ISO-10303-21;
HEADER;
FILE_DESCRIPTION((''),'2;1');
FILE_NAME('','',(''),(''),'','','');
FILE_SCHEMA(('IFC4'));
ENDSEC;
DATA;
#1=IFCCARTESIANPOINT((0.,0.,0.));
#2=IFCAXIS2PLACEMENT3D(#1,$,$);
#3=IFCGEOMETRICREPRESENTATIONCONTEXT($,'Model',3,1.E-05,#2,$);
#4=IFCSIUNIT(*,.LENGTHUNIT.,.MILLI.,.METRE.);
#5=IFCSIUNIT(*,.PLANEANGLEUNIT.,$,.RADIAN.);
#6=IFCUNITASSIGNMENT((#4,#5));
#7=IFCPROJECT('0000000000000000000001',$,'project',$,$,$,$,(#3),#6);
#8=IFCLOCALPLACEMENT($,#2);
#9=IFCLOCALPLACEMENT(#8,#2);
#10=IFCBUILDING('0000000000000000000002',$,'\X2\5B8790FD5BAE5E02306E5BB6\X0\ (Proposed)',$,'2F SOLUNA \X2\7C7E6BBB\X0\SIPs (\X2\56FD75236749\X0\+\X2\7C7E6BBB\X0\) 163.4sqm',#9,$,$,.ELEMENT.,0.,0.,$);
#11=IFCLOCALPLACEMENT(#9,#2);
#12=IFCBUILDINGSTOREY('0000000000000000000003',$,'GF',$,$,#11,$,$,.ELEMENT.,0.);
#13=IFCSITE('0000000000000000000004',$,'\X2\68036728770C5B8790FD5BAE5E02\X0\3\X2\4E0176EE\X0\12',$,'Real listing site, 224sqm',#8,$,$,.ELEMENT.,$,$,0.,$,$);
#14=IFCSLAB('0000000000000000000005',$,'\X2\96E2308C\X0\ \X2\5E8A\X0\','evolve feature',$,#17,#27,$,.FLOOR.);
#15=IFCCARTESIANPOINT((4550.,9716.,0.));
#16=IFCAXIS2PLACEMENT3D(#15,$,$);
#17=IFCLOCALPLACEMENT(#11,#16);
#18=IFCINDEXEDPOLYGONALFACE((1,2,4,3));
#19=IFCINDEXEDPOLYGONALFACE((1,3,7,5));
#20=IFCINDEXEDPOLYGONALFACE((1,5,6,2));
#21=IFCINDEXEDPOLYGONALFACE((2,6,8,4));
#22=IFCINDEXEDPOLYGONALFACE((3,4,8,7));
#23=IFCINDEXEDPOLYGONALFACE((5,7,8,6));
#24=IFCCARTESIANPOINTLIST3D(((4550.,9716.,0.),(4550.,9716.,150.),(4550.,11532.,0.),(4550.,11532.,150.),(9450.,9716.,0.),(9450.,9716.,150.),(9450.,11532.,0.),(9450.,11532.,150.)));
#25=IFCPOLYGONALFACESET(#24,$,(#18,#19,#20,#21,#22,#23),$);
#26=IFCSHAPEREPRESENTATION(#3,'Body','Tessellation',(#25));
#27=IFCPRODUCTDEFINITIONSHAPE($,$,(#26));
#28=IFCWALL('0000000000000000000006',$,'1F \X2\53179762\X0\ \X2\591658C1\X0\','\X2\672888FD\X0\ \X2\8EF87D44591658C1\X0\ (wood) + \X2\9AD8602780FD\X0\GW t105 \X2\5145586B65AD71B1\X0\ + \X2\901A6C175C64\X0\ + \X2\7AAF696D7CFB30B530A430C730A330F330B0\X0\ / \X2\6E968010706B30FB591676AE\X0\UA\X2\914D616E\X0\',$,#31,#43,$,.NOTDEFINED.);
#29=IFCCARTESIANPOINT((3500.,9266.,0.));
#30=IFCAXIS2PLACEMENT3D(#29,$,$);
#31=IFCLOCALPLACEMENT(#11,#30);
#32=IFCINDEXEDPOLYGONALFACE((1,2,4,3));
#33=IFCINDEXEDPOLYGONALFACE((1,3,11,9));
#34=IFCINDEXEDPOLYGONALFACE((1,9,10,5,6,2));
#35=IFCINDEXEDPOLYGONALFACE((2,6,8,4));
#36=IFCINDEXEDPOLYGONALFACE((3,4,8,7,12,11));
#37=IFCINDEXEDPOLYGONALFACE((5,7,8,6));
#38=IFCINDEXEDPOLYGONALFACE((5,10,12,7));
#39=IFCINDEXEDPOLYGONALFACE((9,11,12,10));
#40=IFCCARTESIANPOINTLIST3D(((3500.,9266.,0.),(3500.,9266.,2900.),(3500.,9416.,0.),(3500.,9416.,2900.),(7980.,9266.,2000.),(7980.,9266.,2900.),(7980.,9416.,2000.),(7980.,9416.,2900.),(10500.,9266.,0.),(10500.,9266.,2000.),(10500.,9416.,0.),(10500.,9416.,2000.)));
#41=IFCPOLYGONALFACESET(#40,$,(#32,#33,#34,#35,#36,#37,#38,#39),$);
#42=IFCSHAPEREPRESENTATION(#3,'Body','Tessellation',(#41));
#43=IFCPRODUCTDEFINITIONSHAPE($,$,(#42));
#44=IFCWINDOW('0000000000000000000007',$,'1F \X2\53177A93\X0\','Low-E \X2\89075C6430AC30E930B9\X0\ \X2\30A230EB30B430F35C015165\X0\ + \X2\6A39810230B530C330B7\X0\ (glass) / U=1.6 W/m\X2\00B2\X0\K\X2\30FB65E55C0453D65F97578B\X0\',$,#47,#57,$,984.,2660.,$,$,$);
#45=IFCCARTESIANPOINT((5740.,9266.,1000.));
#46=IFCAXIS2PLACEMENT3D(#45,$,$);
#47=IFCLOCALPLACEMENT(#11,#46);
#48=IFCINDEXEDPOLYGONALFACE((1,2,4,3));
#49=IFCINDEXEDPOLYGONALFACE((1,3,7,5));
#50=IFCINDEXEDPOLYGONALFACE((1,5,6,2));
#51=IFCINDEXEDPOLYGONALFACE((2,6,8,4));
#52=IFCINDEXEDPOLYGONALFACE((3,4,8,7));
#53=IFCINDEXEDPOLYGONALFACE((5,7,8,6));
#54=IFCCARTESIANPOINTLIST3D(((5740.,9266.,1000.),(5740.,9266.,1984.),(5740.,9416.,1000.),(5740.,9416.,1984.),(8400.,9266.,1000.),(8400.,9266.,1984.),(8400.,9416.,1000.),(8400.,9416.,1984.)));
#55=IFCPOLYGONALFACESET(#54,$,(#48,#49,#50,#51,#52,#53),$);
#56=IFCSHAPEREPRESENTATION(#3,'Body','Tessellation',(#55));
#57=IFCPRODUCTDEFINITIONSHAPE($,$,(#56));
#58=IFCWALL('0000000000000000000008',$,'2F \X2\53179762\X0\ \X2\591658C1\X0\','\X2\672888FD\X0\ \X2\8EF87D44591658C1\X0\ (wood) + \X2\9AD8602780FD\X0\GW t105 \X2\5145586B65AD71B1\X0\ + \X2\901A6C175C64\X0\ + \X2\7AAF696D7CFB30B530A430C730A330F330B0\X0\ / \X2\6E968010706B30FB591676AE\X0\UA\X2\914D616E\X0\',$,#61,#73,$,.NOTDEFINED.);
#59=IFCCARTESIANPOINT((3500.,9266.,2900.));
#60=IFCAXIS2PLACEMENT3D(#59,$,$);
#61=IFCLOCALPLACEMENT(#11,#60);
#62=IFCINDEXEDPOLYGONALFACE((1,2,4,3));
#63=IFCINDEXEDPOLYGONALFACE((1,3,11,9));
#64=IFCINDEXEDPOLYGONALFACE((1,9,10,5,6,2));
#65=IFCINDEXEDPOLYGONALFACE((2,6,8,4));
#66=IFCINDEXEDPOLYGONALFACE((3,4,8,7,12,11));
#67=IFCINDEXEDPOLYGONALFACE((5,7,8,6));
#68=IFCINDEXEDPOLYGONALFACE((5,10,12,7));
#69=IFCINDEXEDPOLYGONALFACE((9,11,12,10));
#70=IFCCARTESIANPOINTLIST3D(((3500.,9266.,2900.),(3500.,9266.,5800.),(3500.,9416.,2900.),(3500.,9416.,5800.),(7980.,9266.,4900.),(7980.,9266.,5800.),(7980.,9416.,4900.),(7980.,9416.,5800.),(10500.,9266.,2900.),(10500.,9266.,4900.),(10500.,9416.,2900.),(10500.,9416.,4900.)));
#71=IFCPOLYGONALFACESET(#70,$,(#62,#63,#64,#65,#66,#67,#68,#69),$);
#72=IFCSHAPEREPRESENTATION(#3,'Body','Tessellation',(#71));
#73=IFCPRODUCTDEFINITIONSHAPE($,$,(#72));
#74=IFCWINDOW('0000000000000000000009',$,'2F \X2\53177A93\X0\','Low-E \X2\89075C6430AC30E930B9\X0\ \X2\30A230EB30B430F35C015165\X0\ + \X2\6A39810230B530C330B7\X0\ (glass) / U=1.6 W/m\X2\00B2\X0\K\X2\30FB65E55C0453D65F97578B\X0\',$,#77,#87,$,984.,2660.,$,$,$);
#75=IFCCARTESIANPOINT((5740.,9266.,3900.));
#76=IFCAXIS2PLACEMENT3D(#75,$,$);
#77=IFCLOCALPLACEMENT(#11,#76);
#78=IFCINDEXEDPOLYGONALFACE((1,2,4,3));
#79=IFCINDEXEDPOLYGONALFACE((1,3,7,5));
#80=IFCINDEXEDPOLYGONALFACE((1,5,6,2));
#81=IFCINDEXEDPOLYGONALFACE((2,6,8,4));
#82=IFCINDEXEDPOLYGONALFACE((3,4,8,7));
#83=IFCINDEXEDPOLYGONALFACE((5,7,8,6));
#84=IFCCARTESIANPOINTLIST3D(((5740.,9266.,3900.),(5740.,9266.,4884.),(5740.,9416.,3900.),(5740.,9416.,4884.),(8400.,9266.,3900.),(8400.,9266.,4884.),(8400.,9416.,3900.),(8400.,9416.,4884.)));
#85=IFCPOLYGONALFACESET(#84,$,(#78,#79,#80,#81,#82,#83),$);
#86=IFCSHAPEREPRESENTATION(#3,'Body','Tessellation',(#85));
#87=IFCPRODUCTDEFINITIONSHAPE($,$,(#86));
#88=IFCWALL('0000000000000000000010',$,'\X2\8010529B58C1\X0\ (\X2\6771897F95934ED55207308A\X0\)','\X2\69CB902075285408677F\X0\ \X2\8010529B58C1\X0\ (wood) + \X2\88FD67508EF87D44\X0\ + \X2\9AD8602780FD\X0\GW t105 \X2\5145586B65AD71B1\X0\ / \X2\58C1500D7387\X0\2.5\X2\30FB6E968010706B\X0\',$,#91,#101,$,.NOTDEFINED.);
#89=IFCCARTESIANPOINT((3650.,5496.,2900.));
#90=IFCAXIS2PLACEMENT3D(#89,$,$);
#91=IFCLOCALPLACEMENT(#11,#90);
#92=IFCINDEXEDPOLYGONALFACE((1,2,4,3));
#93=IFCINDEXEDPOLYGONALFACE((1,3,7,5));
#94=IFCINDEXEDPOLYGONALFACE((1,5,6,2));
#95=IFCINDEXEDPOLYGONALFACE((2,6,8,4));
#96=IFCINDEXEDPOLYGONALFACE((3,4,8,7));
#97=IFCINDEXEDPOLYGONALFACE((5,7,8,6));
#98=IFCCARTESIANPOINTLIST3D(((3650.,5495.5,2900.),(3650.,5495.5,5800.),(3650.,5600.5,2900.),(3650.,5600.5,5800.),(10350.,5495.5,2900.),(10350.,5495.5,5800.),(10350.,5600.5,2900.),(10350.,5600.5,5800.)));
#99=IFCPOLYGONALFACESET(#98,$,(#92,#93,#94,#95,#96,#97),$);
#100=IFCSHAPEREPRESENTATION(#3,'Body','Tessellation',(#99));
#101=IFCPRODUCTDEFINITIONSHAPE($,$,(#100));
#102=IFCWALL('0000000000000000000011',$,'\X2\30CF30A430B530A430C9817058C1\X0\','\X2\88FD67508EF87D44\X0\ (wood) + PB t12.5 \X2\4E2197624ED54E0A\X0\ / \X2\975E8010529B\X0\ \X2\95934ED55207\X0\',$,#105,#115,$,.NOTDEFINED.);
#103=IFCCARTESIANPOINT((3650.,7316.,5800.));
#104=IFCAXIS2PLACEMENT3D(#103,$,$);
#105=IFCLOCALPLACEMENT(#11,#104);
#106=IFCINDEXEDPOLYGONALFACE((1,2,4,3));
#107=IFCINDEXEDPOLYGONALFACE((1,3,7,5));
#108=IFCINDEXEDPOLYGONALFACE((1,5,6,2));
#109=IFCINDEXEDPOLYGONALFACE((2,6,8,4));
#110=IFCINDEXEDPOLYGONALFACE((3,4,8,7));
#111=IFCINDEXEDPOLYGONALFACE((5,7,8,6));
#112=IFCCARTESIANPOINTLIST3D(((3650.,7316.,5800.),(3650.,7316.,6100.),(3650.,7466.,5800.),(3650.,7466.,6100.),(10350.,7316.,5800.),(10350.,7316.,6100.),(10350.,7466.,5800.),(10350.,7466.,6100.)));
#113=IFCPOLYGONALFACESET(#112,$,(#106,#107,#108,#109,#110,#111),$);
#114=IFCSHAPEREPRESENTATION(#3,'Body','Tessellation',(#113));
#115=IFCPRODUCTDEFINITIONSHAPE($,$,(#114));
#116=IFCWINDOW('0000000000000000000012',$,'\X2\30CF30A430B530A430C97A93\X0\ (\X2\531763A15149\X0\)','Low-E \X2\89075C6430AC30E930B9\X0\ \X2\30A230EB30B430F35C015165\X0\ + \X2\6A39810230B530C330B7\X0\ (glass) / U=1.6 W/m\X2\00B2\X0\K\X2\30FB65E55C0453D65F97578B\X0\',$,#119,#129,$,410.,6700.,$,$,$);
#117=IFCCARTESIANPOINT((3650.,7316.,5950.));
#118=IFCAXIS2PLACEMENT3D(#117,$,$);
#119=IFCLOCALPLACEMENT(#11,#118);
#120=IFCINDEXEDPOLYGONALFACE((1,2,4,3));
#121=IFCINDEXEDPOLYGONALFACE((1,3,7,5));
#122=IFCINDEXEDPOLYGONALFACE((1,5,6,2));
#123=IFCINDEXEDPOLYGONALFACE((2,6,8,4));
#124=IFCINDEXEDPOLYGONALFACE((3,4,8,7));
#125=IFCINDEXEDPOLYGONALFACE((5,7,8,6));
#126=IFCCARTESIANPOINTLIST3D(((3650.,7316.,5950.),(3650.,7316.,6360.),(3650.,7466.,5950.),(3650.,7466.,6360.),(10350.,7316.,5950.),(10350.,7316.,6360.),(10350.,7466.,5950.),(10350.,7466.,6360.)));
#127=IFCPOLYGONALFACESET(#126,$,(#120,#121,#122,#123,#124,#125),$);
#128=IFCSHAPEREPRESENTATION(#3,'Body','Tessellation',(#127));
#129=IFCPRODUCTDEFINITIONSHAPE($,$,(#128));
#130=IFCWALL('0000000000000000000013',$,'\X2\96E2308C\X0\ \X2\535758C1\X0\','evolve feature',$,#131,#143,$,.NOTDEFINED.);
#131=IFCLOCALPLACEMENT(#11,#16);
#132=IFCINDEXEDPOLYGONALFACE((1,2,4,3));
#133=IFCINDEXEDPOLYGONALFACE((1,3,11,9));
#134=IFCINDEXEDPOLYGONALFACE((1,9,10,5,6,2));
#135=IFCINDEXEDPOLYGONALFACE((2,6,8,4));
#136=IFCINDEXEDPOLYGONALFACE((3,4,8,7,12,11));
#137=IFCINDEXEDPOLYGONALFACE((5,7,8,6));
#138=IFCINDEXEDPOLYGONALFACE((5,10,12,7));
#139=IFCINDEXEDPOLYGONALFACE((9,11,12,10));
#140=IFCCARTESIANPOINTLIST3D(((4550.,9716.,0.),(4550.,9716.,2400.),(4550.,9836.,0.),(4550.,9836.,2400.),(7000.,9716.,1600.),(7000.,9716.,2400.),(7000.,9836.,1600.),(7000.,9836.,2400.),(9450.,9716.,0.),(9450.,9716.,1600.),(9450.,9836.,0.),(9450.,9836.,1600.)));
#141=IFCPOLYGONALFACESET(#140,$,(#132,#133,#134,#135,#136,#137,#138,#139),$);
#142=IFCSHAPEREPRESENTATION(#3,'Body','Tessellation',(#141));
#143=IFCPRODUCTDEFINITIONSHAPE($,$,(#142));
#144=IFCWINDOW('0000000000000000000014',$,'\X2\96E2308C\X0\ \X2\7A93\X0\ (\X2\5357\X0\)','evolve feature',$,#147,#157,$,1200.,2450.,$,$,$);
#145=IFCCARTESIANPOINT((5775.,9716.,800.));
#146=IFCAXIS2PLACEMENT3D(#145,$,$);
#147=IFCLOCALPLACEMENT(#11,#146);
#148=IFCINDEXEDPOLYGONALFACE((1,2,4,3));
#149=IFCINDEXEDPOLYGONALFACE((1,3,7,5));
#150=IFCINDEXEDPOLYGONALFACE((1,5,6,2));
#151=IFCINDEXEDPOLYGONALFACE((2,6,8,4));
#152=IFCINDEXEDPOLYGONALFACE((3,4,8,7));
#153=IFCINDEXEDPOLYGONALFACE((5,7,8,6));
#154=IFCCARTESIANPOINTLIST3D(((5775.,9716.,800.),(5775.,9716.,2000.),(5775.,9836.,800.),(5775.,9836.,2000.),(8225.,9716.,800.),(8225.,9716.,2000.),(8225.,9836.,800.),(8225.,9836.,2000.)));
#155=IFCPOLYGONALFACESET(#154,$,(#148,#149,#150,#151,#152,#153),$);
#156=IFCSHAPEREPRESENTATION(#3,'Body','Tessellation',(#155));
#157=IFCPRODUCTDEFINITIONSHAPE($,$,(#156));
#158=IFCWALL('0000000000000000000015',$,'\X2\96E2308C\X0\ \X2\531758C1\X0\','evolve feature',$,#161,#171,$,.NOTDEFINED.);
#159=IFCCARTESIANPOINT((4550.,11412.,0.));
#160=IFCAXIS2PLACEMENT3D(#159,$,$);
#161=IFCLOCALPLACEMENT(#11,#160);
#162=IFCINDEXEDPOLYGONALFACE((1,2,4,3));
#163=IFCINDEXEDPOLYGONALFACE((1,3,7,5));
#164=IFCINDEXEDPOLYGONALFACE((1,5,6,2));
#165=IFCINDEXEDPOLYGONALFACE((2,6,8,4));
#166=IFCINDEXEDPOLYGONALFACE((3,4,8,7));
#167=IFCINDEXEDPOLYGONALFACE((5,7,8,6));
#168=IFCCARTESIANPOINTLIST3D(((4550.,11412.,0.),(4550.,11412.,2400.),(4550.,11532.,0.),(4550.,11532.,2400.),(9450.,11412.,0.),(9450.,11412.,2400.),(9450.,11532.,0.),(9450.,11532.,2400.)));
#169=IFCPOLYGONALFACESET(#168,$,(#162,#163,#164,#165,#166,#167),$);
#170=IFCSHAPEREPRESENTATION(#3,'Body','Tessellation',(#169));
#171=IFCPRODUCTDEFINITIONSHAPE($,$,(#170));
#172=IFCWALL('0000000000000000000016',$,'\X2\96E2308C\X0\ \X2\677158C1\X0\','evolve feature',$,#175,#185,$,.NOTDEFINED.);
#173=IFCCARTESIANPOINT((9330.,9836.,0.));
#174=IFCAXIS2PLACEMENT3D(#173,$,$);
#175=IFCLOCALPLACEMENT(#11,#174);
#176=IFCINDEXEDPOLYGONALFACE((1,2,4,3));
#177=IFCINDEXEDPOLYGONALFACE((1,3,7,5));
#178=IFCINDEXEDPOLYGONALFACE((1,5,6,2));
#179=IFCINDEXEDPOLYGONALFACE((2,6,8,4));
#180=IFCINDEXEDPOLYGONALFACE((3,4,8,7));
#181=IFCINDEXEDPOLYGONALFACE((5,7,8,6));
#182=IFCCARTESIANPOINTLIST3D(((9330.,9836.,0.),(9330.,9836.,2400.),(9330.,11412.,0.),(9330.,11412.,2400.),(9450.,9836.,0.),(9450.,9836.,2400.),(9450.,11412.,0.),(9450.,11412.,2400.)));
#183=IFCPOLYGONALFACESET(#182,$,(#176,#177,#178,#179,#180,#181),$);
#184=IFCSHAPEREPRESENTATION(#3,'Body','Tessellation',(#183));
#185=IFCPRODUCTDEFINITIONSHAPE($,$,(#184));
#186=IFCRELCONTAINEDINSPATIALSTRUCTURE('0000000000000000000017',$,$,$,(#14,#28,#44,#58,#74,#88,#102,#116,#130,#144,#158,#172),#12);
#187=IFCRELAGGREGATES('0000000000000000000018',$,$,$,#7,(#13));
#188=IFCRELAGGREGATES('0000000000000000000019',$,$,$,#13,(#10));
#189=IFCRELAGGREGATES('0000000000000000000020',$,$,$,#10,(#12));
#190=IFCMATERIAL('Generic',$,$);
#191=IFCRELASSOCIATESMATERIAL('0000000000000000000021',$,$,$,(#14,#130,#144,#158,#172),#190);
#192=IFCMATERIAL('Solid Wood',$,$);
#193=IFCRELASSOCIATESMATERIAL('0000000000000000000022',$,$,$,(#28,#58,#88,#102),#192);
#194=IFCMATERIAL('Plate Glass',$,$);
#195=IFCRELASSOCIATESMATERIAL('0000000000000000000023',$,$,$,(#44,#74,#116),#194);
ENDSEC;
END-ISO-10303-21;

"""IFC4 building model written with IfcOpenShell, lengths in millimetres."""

from ifc_helpers import new_model, si_unit, frame, frame_2d, origin, place, context, project, spatial, rectangle, extrude, material, element, fill, save


model = new_model("IFC4")

# Units and contexts
model_context = context("Model", 3, precision=1e-05, world=origin())
ifc_project = project(units=[si_unit("LENGTHUNIT", "METRE", prefix="MILLI"), si_unit("PLANEANGLEUNIT", "RADIAN")], contexts=[model_context])

# Site, building, storey
site_placement = place(None, origin())
site = spatial("IfcSite", under=ifc_project, at=site_placement, Name="栃木県宇都宮市3丁目12", ObjectType="Real listing site, 224sqm", CompositionType="ELEMENT", RefElevation=0.0)
building_placement = place(site_placement, origin())
building = spatial("IfcBuilding", under=site, at=building_placement, Name="宇都宮市の家 (Proposed)", ObjectType="2F SOLUNA 籾殻SIPs (国産杉+籾殻) 163.4sqm", CompositionType="ELEMENT", ElevationOfRefHeight=0.0, ElevationOfTerrain=0.0)
storey_placement = place(building_placement, origin())
storey = spatial("IfcBuildingStorey", under=building, at=storey_placement, Name="GF", CompositionType="ELEMENT", Elevation=0.0)

# Slab
ifc_material_1 = material(Name="Generic")
slab_placement = place(storey_placement, frame((4550.0, 9716.0, 0.0)))
element("IfcSlab", 1, at=slab_placement, inside=storey, material=ifc_material_1, Name="離れ 床", Description="evolve feature", PredefinedType="FLOOR", context=model_context, shape_type="SweptSolid", body=[
    extrude(rectangle(XDim=4900.0, YDim=1816.0, at=frame_2d((2450.0, 908.0))), frame((4550.0, 9716.0, 0.0)), (0.0, 0.0, 1.0), 150.0),
])

# Wall, opening, window
ifc_material_2 = material(Name="Solid Wood")
wall_1_placement = place(storey_placement, frame((3500.0, 9266.0, 0.0)))
wall_1 = element("IfcWall", 2, at=wall_1_placement, inside=storey, material=ifc_material_2, Name="1F 北面 外壁", Description="木製 軸組外壁 (wood) + 高性能GW t105 充填断熱 + 通気層 + 窯業系サイディング / 準耐火・外皮UA配慮", PredefinedType="NOTDEFINED", context=model_context, shape_type="SweptSolid", body=[
    extrude(rectangle(XDim=7000.0, YDim=150.0, at=frame_2d((3500.0, 75.0))), frame((3500.0, 9266.0, 0.0)), (0.0, 0.0, 1.0), 2900.0),
])
opening_1_placement = place(storey_placement, frame((5740.0, 9266.0, 1000.0)))
opening_1 = element("IfcOpeningElement", 3, at=opening_1_placement, cuts=wall_1, PredefinedType="NOTDEFINED", context=model_context, shape_type="SweptSolid", body=[
    extrude(rectangle(XDim=2660.0, YDim=150.0, at=frame_2d((1330.0, 75.0))), frame((5740.0, 9266.0, 1000.0)), (0.0, 0.0, 1.0), 984.0),
])
ifc_material_3 = material(Name="Plate Glass")
window_1_placement = place(storey_placement, frame((5740.0, 9266.0, 1000.0)))
window_1 = element("IfcWindow", 4, at=window_1_placement, inside=storey, material=ifc_material_3, Name="1F 北窓", Description="Low-E 複層ガラス アルゴン封入 + 樹脂サッシ (glass) / U=1.6 W/m²K・日射取得型", OverallHeight=984.0, OverallWidth=2660.0, context=model_context, shape_type="SweptSolid", body=[
    extrude(rectangle(XDim=2660.0, YDim=150.0, at=frame_2d((1330.0, 75.0))), frame((5740.0, 9266.0, 1000.0)), (0.0, 0.0, 1.0), 984.0),
])
fill(opening_1, window_1)

# Wall, opening, window
wall_2_placement = place(storey_placement, frame((3500.0, 9266.0, 2900.0)))
wall_2 = element("IfcWall", 5, at=wall_2_placement, inside=storey, material=ifc_material_2, Name="2F 北面 外壁", Description="木製 軸組外壁 (wood) + 高性能GW t105 充填断熱 + 通気層 + 窯業系サイディング / 準耐火・外皮UA配慮", PredefinedType="NOTDEFINED", context=model_context, shape_type="SweptSolid", body=[
    extrude(rectangle(XDim=7000.0, YDim=150.0, at=frame_2d((3500.0, 75.0))), frame((3500.0, 9266.0, 2900.0)), (0.0, 0.0, 1.0), 2900.0),
])
opening_2_placement = place(storey_placement, frame((5740.0, 9266.0, 3900.0)))
opening_2 = element("IfcOpeningElement", 6, at=opening_2_placement, cuts=wall_2, PredefinedType="NOTDEFINED", context=model_context, shape_type="SweptSolid", body=[
    extrude(rectangle(XDim=2660.0, YDim=150.0, at=frame_2d((1330.0, 75.0))), frame((5740.0, 9266.0, 3900.0)), (0.0, 0.0, 1.0), 984.0),
])
window_2_placement = place(storey_placement, frame((5740.0, 9266.0, 3900.0)))
window_2 = element("IfcWindow", 7, at=window_2_placement, inside=storey, material=ifc_material_3, Name="2F 北窓", Description="Low-E 複層ガラス アルゴン封入 + 樹脂サッシ (glass) / U=1.6 W/m²K・日射取得型", OverallHeight=984.0, OverallWidth=2660.0, context=model_context, shape_type="SweptSolid", body=[
    extrude(rectangle(XDim=2660.0, YDim=150.0, at=frame_2d((1330.0, 75.0))), frame((5740.0, 9266.0, 3900.0)), (0.0, 0.0, 1.0), 984.0),
])
fill(opening_2, window_2)

# Wall
wall_3_placement = place(storey_placement, frame((3650.0, 5496.0, 2900.0)))
element("IfcWall", 8, at=wall_3_placement, inside=storey, material=ifc_material_2, Name="耐力壁 (東西間仕切り)", Description="構造用合板 耐力壁 (wood) + 製材軸組 + 高性能GW t105 充填断熱 / 壁倍率2.5・準耐火", PredefinedType="NOTDEFINED", context=model_context, shape_type="SweptSolid", body=[
    extrude(rectangle(XDim=6700.0, YDim=105.0, at=frame_2d((3350.0, 52.0))), frame((3650.0, 5496.0, 2900.0)), (0.0, 0.0, 1.0), 2900.0),
])

# Walls, openings, windows
wall_4_placement = place(storey_placement, frame((3650.0, 7316.0, 5800.0)))
wall_4 = element("IfcWall", 9, at=wall_4_placement, inside=storey, material=ifc_material_2, Name="ハイサイド腰壁", Description="製材軸組 (wood) + PB t12.5 両面仕上 / 非耐力 間仕切", PredefinedType="NOTDEFINED", context=model_context, shape_type="SweptSolid", body=[
    extrude(rectangle(XDim=6700.0, YDim=150.0, at=frame_2d((3350.0, 75.0))), frame((3650.0, 7316.0, 5800.0)), (0.0, 0.0, 1.0), 700.0),
])
opening_3_placement = place(storey_placement, frame((3650.0, 7316.0, 5950.0)))
opening_3 = element("IfcOpeningElement", 10, at=opening_3_placement, cuts=wall_4, PredefinedType="NOTDEFINED", context=model_context, shape_type="SweptSolid", body=[
    extrude(rectangle(XDim=6700.0, YDim=150.0, at=frame_2d((3350.0, 75.0))), frame((3650.0, 7316.0, 5950.0)), (0.0, 0.0, 1.0), 410.0),
])
window_3_placement = place(storey_placement, frame((3650.0, 7316.0, 5950.0)))
window_3 = element("IfcWindow", 11, at=window_3_placement, inside=storey, material=ifc_material_3, Name="ハイサイド窓 (北採光)", Description="Low-E 複層ガラス アルゴン封入 + 樹脂サッシ (glass) / U=1.6 W/m²K・日射取得型", OverallHeight=410.0, OverallWidth=6700.0, context=model_context, shape_type="SweptSolid", body=[
    extrude(rectangle(XDim=6700.0, YDim=150.0, at=frame_2d((3350.0, 75.0))), frame((3650.0, 7316.0, 5950.0)), (0.0, 0.0, 1.0), 410.0),
])
fill(opening_3, window_3)
wall_5_placement = place(storey_placement, frame((4550.0, 9716.0, 0.0)))
wall_5 = element("IfcWall", 12, at=wall_5_placement, inside=storey, material=ifc_material_1, Name="離れ 南壁", Description="evolve feature", PredefinedType="NOTDEFINED", context=model_context, shape_type="SweptSolid", body=[
    extrude(rectangle(XDim=4900.0, YDim=120.0, at=frame_2d((2450.0, 60.0))), frame((4550.0, 9716.0, 0.0)), (0.0, 0.0, 1.0), 2400.0),
])
opening_4_placement = place(storey_placement, frame((5775.0, 9716.0, 800.0)))
opening_4 = element("IfcOpeningElement", 13, at=opening_4_placement, cuts=wall_5, PredefinedType="NOTDEFINED", context=model_context, shape_type="SweptSolid", body=[
    extrude(rectangle(XDim=2450.0, YDim=120.0, at=frame_2d((1225.0, 60.0))), frame((5775.0, 9716.0, 800.0)), (0.0, 0.0, 1.0), 1200.0),
])
window_4_placement = place(storey_placement, frame((5775.0, 9716.0, 800.0)))
window_4 = element("IfcWindow", 14, at=window_4_placement, inside=storey, material=ifc_material_1, Name="離れ 窓 (南)", Description="evolve feature", OverallHeight=1200.0, OverallWidth=2450.0, context=model_context, shape_type="SweptSolid", body=[
    extrude(rectangle(XDim=2450.0, YDim=120.0, at=frame_2d((1225.0, 60.0))), frame((5775.0, 9716.0, 800.0)), (0.0, 0.0, 1.0), 1200.0),
])
fill(opening_4, window_4)

# Walls
wall_6_placement = place(storey_placement, frame((4550.0, 11412.0, 0.0)))
element("IfcWall", 15, at=wall_6_placement, inside=storey, material=ifc_material_1, Name="離れ 北壁", Description="evolve feature", PredefinedType="NOTDEFINED", context=model_context, shape_type="SweptSolid", body=[
    extrude(rectangle(XDim=4900.0, YDim=120.0, at=frame_2d((2450.0, 60.0))), frame((4550.0, 11412.0, 0.0)), (0.0, 0.0, 1.0), 2400.0),
])
wall_7_placement = place(storey_placement, frame((9330.0, 9836.0, 0.0)))
element("IfcWall", 16, at=wall_7_placement, inside=storey, material=ifc_material_1, Name="離れ 東壁", Description="evolve feature", PredefinedType="NOTDEFINED", context=model_context, shape_type="SweptSolid", body=[
    extrude(rectangle(XDim=120.0, YDim=1576.0, at=frame_2d((60.0, 788.0))), frame((9330.0, 9836.0, 0.0)), (0.0, 0.0, 1.0), 2400.0),
])

save(model, "model.ifc")
